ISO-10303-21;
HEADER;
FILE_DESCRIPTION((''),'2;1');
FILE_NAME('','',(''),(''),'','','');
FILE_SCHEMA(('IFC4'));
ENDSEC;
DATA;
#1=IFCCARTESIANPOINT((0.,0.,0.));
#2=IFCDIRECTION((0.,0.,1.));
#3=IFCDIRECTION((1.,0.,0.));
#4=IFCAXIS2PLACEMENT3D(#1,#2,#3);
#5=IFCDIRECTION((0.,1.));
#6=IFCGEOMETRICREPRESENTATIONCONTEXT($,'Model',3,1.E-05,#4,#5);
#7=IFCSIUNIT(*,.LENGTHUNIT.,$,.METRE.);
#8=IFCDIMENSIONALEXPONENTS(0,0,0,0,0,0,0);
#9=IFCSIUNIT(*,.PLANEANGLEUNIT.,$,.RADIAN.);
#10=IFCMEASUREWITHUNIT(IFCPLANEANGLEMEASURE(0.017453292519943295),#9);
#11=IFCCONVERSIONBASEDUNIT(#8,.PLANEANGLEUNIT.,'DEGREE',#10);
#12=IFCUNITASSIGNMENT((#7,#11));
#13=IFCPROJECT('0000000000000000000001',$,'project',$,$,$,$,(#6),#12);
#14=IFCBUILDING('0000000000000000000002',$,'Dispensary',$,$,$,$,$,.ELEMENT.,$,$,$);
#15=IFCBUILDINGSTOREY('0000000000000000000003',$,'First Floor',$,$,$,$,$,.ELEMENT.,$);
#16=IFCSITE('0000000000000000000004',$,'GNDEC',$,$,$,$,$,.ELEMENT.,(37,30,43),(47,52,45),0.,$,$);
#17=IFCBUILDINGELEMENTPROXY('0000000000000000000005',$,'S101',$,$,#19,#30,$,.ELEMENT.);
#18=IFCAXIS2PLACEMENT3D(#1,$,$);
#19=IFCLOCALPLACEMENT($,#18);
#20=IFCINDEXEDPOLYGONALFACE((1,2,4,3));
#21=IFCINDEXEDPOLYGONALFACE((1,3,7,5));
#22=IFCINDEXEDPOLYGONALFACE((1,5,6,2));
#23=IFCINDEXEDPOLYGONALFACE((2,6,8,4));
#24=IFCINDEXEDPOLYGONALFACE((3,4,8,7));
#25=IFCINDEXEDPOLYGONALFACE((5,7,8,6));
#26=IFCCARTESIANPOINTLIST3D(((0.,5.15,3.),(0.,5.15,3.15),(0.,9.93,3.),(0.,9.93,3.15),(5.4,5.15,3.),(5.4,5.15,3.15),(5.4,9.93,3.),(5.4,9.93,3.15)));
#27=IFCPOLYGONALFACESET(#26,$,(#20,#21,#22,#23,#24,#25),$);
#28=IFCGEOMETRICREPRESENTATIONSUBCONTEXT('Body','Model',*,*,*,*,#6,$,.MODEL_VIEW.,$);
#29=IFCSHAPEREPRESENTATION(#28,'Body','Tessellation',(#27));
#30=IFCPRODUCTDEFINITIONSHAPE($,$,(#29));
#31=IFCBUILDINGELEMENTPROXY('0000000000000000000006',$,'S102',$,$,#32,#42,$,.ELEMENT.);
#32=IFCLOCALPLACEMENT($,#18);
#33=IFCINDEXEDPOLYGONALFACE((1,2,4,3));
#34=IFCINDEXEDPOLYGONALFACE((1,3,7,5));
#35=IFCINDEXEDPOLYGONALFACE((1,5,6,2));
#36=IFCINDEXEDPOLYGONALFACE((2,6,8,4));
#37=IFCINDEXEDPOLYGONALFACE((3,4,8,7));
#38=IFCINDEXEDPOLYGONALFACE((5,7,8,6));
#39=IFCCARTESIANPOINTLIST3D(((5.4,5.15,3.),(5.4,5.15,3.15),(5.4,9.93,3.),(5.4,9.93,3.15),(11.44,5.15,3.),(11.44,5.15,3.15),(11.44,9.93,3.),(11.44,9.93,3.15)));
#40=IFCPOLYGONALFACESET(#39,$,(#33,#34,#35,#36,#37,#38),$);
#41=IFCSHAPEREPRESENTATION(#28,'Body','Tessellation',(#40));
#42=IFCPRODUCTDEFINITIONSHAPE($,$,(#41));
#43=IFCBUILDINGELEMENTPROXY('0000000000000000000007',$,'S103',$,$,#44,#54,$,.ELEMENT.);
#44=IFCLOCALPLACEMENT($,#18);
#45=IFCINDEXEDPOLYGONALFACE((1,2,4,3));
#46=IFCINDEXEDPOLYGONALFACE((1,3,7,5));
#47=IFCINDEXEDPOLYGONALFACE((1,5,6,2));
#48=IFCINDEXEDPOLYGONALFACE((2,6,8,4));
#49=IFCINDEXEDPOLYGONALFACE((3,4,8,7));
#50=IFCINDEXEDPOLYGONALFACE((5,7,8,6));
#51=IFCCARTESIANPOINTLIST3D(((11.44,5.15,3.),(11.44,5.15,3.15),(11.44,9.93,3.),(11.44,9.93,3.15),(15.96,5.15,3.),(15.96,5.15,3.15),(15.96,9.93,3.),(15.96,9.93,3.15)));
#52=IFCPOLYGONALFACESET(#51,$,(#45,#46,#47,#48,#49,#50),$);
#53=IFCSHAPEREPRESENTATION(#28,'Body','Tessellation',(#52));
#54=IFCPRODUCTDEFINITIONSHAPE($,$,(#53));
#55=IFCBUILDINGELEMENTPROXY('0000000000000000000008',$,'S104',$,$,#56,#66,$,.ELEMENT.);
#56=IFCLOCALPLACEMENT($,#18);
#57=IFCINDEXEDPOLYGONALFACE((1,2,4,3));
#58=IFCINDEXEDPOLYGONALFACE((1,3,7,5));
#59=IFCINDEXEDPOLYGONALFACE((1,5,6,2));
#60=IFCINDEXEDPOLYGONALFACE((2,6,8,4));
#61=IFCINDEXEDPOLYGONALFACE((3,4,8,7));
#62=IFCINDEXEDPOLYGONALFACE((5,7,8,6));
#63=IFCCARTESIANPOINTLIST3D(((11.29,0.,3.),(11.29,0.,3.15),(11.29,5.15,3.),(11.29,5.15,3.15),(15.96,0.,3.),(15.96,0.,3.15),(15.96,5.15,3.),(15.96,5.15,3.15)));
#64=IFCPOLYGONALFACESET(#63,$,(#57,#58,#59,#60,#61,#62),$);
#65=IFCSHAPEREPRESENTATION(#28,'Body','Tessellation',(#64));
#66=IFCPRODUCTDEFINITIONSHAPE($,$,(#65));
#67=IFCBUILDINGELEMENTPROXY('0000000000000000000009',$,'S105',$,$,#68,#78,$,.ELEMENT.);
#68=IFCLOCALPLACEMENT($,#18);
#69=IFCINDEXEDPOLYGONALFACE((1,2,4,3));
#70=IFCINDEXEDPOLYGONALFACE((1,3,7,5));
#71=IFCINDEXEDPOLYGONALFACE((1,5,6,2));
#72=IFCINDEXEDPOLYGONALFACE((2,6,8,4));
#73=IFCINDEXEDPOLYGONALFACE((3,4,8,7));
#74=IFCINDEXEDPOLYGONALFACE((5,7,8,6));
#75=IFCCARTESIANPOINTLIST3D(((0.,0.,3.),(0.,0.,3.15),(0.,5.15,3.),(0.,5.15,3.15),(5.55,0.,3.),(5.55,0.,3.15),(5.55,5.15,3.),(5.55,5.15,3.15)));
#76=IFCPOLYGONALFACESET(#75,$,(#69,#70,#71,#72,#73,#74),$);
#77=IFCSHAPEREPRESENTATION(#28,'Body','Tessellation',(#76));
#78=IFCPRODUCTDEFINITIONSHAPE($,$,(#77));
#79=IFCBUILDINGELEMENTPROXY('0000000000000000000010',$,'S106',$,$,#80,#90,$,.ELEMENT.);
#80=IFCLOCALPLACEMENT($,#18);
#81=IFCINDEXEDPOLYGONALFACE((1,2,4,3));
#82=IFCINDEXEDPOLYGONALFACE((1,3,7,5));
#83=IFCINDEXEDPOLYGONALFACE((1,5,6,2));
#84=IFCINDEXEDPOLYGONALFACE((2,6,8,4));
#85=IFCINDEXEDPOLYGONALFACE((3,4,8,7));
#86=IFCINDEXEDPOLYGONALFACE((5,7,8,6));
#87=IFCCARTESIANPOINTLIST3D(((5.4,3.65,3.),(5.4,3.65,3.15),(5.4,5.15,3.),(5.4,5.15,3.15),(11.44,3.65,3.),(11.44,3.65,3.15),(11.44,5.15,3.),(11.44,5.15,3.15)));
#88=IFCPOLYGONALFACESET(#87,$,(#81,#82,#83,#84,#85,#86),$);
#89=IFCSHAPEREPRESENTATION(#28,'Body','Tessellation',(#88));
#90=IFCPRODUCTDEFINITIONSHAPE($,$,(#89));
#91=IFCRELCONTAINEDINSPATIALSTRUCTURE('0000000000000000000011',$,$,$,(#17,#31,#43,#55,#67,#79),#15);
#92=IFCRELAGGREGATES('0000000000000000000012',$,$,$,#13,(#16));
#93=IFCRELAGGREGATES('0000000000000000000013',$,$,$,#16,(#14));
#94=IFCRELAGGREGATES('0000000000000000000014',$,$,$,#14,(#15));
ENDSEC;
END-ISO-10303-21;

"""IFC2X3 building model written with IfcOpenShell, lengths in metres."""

from ifc_helpers import new_model, entity, si_unit, converted_unit, direction, frame, frame_2d, origin_with_axes, place, context, subcontext, project, spatial, rectangle, extrude, element, save


model = new_model("IFC2X3")

# Units and contexts
model_context = context("Model", 3, precision=1e-05, world=origin_with_axes(), true_north=direction((0.0, 1.0)))
body_context = subcontext(model_context, "Body", "Model", "MODEL_VIEW")
ifc_project = project(units=[si_unit("LENGTHUNIT", "METRE"), converted_unit("PLANEANGLEUNIT", "DEGREE", entity("IfcPlaneAngleMeasure", 0.017453292519943295), si_unit("PLANEANGLEUNIT", "RADIAN"), dimensions=[0, 0, 0, 0, 0, 0, 0])], contexts=[model_context])

# Site, building, storey
site = spatial("IfcSite", under=ifc_project, Name="GNDEC", CompositionType="ELEMENT", RefLatitude=(37, 30, 43), RefLongitude=(47, 52, 45), RefElevation=0.0)
building = spatial("IfcBuilding", under=site, Name="Dispensary", CompositionType="ELEMENT")
storey = spatial("IfcBuildingStorey", under=building, Name="First Floor", CompositionType="ELEMENT")

# Building element proxies
placement = place(None, origin_with_axes())
element("IfcBuildingElementProxy", 1, at=placement, inside=storey, Name="S101", CompositionType="ELEMENT", context=body_context, shape_type="SweptSolid", body=[
    extrude(rectangle(XDim=5.4, YDim=4.78, at=frame_2d((0.0, 0.0), x_axis=(-1.0, 0.0))), frame((2.7, 7.54, 3.0), z_axis=(0.0, 0.0, 1.0), x_axis=(1.0, 0.0, 0.0)), (0.0, 0.0, 1.0), 0.15),
])
element("IfcBuildingElementProxy", 2, at=placement, inside=storey, Name="S102", CompositionType="ELEMENT", context=body_context, shape_type="SweptSolid", body=[
    extrude(rectangle(XDim=6.04, YDim=4.78, at=frame_2d((0.0, 0.0), x_axis=(-1.0, 0.0))), frame((8.42, 7.54, 3.0), z_axis=(0.0, 0.0, 1.0), x_axis=(1.0, 0.0, 0.0)), (0.0, 0.0, 1.0), 0.15),
])
element("IfcBuildingElementProxy", 3, at=placement, inside=storey, Name="S103", CompositionType="ELEMENT", context=body_context, shape_type="SweptSolid", body=[
    extrude(rectangle(XDim=4.52, YDim=4.78, at=frame_2d((0.0, 0.0), x_axis=(-1.0, 0.0))), frame((13.7, 7.54, 3.0), z_axis=(0.0, 0.0, 1.0), x_axis=(1.0, 0.0, 0.0)), (0.0, 0.0, 1.0), 0.15),
])
element("IfcBuildingElementProxy", 4, at=placement, inside=storey, Name="S104", CompositionType="ELEMENT", context=body_context, shape_type="SweptSolid", body=[
    extrude(rectangle(XDim=4.67, YDim=5.15, at=frame_2d((0.0, 0.0), x_axis=(-1.0, 0.0))), frame((13.625, 2.575, 3.0), z_axis=(0.0, 0.0, 1.0), x_axis=(1.0, 0.0, 0.0)), (0.0, 0.0, 1.0), 0.15),
])
element("IfcBuildingElementProxy", 5, at=placement, inside=storey, Name="S105", CompositionType="ELEMENT", context=body_context, shape_type="SweptSolid", body=[
    extrude(rectangle(XDim=5.55, YDim=5.15, at=frame_2d((0.0, 0.0), x_axis=(-1.0, 0.0))), frame((2.775, 2.575, 3.0), z_axis=(0.0, 0.0, 1.0), x_axis=(1.0, 0.0, 0.0)), (0.0, 0.0, 1.0), 0.15),
])
element("IfcBuildingElementProxy", 6, at=placement, inside=storey, Name="S106", CompositionType="ELEMENT", context=body_context, shape_type="SweptSolid", body=[
    extrude(rectangle(XDim=6.04, YDim=1.5, at=frame_2d((0.0, 0.0), x_axis=(-1.0, 0.0))), frame((8.42, 4.4, 3.0), z_axis=(0.0, 0.0, 1.0), x_axis=(1.0, 0.0, 0.0)), (0.0, 0.0, 1.0), 0.15),
])

save(model, "model.ifc")
